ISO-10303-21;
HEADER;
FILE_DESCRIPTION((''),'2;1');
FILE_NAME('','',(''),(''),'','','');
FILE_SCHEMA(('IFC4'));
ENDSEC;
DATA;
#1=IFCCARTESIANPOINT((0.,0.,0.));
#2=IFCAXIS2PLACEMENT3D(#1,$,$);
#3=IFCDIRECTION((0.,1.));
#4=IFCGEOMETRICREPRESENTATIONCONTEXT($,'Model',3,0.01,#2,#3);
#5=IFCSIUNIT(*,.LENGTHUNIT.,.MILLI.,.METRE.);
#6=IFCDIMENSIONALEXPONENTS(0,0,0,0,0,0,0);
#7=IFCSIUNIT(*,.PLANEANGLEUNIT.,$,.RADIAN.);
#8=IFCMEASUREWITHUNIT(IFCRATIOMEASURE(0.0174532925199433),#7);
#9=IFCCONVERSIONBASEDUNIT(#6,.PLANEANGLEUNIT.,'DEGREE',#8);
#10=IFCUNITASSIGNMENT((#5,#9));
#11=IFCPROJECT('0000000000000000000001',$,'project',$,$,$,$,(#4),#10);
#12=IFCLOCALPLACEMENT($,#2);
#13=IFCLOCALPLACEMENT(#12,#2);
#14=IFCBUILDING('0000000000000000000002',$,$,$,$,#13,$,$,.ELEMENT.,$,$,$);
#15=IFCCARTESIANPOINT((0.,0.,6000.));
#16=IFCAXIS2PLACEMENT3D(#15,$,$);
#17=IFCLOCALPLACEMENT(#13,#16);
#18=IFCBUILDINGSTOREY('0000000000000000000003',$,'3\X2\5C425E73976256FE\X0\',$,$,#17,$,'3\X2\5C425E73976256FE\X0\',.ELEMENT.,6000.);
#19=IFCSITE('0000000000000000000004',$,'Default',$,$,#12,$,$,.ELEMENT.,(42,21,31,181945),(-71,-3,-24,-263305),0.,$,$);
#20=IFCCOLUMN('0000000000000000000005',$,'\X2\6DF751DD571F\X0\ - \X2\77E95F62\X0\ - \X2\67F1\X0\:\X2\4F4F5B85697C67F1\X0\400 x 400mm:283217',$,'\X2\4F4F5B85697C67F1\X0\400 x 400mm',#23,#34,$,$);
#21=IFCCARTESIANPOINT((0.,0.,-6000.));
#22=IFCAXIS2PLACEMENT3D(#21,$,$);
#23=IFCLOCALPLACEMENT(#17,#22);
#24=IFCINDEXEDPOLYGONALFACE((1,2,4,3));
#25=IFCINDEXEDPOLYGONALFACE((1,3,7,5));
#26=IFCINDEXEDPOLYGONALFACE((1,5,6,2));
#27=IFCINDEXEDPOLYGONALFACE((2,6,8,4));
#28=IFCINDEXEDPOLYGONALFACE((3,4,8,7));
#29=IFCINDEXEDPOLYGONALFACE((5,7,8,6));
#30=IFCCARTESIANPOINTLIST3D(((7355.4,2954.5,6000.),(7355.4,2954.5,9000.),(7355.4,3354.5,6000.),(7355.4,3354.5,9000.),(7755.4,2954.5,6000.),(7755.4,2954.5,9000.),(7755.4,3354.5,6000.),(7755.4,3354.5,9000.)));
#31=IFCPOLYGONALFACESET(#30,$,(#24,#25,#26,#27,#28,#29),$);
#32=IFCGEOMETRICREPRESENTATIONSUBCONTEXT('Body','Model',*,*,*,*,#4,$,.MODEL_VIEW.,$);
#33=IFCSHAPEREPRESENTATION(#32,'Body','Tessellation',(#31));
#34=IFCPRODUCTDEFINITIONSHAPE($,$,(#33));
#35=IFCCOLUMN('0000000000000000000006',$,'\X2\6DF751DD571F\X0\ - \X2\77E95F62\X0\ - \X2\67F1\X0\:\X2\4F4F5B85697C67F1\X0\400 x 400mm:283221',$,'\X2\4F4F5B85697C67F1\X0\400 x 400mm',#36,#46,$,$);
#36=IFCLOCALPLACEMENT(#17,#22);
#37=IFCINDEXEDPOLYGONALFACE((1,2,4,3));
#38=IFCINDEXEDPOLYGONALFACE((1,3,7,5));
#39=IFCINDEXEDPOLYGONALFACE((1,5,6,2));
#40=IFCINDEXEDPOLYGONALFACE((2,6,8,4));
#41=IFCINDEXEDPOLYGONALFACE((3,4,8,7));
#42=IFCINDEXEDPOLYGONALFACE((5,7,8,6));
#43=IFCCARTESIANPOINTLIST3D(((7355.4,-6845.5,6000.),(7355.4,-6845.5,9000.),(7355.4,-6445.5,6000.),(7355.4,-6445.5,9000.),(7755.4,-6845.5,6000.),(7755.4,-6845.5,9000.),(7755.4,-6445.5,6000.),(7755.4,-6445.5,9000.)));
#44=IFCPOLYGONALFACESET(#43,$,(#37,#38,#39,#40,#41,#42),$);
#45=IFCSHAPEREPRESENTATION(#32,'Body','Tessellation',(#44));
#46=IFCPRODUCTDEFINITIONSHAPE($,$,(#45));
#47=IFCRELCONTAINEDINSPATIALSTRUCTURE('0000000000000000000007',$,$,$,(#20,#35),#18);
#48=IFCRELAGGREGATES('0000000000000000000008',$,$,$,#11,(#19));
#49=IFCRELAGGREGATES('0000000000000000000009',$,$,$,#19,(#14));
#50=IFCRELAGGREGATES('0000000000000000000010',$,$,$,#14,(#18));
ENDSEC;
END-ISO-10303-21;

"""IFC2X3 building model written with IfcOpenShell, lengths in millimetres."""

from ifc_helpers import new_model, entity, si_unit, converted_unit, direction, frame, origin, origin_2d_with_axis, place, context, subcontext, project, spatial, rectangle, extrude, source, transform, mapped, element, save


model = new_model("IFC2X3")

# Units and contexts
model_context = context("Model", 3, precision=0.01, world=origin(), true_north=direction((0.0, 1.0)))
body_context = subcontext(model_context, "Body", "Model", "MODEL_VIEW")
ifc_project = project(units=[si_unit("LENGTHUNIT", "METRE", prefix="MILLI"), converted_unit("PLANEANGLEUNIT", "DEGREE", entity("IfcRatioMeasure", 0.0174532925199433), si_unit("PLANEANGLEUNIT", "RADIAN"), dimensions=[0, 0, 0, 0, 0, 0, 0])], contexts=[model_context])

# Site, building, storey
site_placement = place(None, origin())
site = spatial("IfcSite", under=ifc_project, at=site_placement, Name="Default", CompositionType="ELEMENT", RefLatitude=(42, 21, 31, 181945), RefLongitude=(-71, -3, -24, -263305), RefElevation=0.0)
building_placement = place(site_placement, origin())
building = spatial("IfcBuilding", under=site, at=building_placement, CompositionType="ELEMENT")
storey_placement = place(building_placement, frame((0.0, 0.0, 6000.0)))
storey = spatial("IfcBuildingStorey", under=building, at=storey_placement, Name="3层平面图", LongName="3层平面图", CompositionType="ELEMENT", Elevation=6000.0)

# Columns
shared_shape_1 = source(origin(), body_context, "Body", "SweptSolid", [
    extrude(rectangle(XDim=400.0, YDim=400.0, at=origin_2d_with_axis()), frame((7555.4, 3154.5, 6000.0), z_axis=(0.0, 0.0, 1.0), x_axis=(0.0, -1.0, 0.0)), (0.0, 0.0, 1.0), 3000.0),
])
column_1_placement = place(storey_placement, frame((0.0, 0.0, -6000.0)))
element("IfcColumn", 1, at=column_1_placement, inside=storey, Name="混凝土 - 矩形 - 柱:住宅楼柱400 x 400mm:283217", ObjectType="住宅楼柱400 x 400mm", context=body_context, shape_type="MappedRepresentation", body=[
    mapped(shared_shape_1, transform((0.0, 0.0, 0.0), scale=1.0)),
])
shared_shape_2 = source(origin(), body_context, "Body", "SweptSolid", [
    extrude(rectangle(XDim=400.0, YDim=400.0, at=origin_2d_with_axis()), frame((7555.4, -6645.5, 6000.0), z_axis=(0.0, 0.0, 1.0), x_axis=(0.0, -1.0, 0.0)), (0.0, 0.0, 1.0), 3000.0),
])
column_2_placement = place(storey_placement, frame((0.0, 0.0, -6000.0)))
element("IfcColumn", 2, at=column_2_placement, inside=storey, Name="混凝土 - 矩形 - 柱:住宅楼柱400 x 400mm:283221", ObjectType="住宅楼柱400 x 400mm", context=body_context, shape_type="MappedRepresentation", body=[
    mapped(shared_shape_2, transform((0.0, 0.0, 0.0), scale=1.0)),
])

save(model, "model.ifc")
